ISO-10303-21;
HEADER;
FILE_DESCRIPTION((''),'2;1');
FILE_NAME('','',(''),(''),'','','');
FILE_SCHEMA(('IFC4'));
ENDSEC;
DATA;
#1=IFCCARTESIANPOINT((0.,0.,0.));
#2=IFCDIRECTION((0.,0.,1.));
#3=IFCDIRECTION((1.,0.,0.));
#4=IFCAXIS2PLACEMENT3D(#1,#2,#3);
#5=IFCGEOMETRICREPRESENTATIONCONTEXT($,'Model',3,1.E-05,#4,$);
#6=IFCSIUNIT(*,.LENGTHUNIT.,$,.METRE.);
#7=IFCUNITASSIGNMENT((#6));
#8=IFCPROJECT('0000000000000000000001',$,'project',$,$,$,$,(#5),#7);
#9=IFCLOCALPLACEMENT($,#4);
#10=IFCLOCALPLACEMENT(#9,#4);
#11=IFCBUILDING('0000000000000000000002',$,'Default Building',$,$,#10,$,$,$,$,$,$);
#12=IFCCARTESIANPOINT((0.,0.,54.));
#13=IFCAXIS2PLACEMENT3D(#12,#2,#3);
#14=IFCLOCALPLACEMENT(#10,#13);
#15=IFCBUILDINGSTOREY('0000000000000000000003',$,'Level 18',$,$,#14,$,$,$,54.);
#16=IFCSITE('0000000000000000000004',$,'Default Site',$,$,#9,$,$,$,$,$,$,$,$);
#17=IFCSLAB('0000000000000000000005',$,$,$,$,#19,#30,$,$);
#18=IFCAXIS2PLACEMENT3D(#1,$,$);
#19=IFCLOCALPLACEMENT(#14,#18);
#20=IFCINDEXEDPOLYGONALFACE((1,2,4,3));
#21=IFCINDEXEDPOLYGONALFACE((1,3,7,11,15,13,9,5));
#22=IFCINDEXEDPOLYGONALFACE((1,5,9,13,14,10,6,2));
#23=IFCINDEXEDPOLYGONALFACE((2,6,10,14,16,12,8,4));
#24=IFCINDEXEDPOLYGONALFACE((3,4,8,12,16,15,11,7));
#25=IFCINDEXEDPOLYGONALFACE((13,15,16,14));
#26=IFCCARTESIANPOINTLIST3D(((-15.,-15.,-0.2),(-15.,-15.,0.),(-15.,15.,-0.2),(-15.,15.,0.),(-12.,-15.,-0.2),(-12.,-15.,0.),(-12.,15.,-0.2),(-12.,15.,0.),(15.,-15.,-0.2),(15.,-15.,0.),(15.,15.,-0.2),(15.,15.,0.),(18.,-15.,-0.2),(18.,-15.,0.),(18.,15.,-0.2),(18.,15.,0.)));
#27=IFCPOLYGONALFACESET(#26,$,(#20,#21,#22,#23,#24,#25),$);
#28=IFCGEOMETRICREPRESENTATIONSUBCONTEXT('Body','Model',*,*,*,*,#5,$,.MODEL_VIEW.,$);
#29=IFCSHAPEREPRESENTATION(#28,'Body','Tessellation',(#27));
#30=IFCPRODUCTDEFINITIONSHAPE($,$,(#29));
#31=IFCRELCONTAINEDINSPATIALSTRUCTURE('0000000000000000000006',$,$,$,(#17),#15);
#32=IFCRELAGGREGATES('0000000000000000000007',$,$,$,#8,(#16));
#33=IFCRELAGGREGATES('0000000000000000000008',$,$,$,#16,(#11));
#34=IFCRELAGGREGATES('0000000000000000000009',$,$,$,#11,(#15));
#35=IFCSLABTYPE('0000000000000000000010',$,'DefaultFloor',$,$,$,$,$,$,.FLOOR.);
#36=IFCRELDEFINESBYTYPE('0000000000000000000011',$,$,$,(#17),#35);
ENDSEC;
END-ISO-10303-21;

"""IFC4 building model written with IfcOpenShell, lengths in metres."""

from ifc_helpers import new_model, si_unit, frame, origin_with_axes, place, context, subcontext, project, spatial, polyline, outline, extrude, type_object, element, save


model = new_model("IFC4")

# Units and contexts
model_context = context("Model", 3, precision=1e-05, world=origin_with_axes())
body_context = subcontext(model_context, "Body", "Model", "MODEL_VIEW")
ifc_project = project(units=[si_unit("LENGTHUNIT", "METRE")], contexts=[model_context])

# Site, building, storey
site_placement = place(None, origin_with_axes())
site = spatial("IfcSite", under=ifc_project, at=site_placement, Name="Default Site")
building_placement = place(site_placement, origin_with_axes())
building = spatial("IfcBuilding", under=site, at=building_placement, Name="Default Building")
storey_placement = place(building_placement, frame((0.0, 0.0, 54.0), z_axis=(0.0, 0.0, 1.0), x_axis=(1.0, 0.0, 0.0)))
storey = spatial("IfcBuildingStorey", under=building, at=storey_placement, Name="Level 18", Elevation=54.0)

# Slab
slab_type = type_object("IfcSlabType", Name="DefaultFloor", PredefinedType="FLOOR")
slab_placement = place(storey_placement, frame((0.0, 0.0, -54.0), z_axis=(0.0, 0.0, 1.0), x_axis=(1.0, 0.0, 0.0)))
element("IfcSlab", 1, at=slab_placement, inside=storey, type_object=slab_type, context=body_context, shape_type="SweptSolid", body=[
    extrude(outline(polyline([(-15.0, 15.0), (-12.0, 15.0), (15.0, 15.0), (18.0, 15.0), (18.0, -15.0), (15.0, -15.0), (-12.0, -15.0), (-15.0, -15.0), (-15.0, 15.0)])), frame((0.0, 0.0, 54.0), z_axis=(0.0, 0.0, 1.0), x_axis=(1.0, 0.0, 0.0)), (0.0, 0.0, -1.0), 0.2),
])

save(model, "model.ifc")
